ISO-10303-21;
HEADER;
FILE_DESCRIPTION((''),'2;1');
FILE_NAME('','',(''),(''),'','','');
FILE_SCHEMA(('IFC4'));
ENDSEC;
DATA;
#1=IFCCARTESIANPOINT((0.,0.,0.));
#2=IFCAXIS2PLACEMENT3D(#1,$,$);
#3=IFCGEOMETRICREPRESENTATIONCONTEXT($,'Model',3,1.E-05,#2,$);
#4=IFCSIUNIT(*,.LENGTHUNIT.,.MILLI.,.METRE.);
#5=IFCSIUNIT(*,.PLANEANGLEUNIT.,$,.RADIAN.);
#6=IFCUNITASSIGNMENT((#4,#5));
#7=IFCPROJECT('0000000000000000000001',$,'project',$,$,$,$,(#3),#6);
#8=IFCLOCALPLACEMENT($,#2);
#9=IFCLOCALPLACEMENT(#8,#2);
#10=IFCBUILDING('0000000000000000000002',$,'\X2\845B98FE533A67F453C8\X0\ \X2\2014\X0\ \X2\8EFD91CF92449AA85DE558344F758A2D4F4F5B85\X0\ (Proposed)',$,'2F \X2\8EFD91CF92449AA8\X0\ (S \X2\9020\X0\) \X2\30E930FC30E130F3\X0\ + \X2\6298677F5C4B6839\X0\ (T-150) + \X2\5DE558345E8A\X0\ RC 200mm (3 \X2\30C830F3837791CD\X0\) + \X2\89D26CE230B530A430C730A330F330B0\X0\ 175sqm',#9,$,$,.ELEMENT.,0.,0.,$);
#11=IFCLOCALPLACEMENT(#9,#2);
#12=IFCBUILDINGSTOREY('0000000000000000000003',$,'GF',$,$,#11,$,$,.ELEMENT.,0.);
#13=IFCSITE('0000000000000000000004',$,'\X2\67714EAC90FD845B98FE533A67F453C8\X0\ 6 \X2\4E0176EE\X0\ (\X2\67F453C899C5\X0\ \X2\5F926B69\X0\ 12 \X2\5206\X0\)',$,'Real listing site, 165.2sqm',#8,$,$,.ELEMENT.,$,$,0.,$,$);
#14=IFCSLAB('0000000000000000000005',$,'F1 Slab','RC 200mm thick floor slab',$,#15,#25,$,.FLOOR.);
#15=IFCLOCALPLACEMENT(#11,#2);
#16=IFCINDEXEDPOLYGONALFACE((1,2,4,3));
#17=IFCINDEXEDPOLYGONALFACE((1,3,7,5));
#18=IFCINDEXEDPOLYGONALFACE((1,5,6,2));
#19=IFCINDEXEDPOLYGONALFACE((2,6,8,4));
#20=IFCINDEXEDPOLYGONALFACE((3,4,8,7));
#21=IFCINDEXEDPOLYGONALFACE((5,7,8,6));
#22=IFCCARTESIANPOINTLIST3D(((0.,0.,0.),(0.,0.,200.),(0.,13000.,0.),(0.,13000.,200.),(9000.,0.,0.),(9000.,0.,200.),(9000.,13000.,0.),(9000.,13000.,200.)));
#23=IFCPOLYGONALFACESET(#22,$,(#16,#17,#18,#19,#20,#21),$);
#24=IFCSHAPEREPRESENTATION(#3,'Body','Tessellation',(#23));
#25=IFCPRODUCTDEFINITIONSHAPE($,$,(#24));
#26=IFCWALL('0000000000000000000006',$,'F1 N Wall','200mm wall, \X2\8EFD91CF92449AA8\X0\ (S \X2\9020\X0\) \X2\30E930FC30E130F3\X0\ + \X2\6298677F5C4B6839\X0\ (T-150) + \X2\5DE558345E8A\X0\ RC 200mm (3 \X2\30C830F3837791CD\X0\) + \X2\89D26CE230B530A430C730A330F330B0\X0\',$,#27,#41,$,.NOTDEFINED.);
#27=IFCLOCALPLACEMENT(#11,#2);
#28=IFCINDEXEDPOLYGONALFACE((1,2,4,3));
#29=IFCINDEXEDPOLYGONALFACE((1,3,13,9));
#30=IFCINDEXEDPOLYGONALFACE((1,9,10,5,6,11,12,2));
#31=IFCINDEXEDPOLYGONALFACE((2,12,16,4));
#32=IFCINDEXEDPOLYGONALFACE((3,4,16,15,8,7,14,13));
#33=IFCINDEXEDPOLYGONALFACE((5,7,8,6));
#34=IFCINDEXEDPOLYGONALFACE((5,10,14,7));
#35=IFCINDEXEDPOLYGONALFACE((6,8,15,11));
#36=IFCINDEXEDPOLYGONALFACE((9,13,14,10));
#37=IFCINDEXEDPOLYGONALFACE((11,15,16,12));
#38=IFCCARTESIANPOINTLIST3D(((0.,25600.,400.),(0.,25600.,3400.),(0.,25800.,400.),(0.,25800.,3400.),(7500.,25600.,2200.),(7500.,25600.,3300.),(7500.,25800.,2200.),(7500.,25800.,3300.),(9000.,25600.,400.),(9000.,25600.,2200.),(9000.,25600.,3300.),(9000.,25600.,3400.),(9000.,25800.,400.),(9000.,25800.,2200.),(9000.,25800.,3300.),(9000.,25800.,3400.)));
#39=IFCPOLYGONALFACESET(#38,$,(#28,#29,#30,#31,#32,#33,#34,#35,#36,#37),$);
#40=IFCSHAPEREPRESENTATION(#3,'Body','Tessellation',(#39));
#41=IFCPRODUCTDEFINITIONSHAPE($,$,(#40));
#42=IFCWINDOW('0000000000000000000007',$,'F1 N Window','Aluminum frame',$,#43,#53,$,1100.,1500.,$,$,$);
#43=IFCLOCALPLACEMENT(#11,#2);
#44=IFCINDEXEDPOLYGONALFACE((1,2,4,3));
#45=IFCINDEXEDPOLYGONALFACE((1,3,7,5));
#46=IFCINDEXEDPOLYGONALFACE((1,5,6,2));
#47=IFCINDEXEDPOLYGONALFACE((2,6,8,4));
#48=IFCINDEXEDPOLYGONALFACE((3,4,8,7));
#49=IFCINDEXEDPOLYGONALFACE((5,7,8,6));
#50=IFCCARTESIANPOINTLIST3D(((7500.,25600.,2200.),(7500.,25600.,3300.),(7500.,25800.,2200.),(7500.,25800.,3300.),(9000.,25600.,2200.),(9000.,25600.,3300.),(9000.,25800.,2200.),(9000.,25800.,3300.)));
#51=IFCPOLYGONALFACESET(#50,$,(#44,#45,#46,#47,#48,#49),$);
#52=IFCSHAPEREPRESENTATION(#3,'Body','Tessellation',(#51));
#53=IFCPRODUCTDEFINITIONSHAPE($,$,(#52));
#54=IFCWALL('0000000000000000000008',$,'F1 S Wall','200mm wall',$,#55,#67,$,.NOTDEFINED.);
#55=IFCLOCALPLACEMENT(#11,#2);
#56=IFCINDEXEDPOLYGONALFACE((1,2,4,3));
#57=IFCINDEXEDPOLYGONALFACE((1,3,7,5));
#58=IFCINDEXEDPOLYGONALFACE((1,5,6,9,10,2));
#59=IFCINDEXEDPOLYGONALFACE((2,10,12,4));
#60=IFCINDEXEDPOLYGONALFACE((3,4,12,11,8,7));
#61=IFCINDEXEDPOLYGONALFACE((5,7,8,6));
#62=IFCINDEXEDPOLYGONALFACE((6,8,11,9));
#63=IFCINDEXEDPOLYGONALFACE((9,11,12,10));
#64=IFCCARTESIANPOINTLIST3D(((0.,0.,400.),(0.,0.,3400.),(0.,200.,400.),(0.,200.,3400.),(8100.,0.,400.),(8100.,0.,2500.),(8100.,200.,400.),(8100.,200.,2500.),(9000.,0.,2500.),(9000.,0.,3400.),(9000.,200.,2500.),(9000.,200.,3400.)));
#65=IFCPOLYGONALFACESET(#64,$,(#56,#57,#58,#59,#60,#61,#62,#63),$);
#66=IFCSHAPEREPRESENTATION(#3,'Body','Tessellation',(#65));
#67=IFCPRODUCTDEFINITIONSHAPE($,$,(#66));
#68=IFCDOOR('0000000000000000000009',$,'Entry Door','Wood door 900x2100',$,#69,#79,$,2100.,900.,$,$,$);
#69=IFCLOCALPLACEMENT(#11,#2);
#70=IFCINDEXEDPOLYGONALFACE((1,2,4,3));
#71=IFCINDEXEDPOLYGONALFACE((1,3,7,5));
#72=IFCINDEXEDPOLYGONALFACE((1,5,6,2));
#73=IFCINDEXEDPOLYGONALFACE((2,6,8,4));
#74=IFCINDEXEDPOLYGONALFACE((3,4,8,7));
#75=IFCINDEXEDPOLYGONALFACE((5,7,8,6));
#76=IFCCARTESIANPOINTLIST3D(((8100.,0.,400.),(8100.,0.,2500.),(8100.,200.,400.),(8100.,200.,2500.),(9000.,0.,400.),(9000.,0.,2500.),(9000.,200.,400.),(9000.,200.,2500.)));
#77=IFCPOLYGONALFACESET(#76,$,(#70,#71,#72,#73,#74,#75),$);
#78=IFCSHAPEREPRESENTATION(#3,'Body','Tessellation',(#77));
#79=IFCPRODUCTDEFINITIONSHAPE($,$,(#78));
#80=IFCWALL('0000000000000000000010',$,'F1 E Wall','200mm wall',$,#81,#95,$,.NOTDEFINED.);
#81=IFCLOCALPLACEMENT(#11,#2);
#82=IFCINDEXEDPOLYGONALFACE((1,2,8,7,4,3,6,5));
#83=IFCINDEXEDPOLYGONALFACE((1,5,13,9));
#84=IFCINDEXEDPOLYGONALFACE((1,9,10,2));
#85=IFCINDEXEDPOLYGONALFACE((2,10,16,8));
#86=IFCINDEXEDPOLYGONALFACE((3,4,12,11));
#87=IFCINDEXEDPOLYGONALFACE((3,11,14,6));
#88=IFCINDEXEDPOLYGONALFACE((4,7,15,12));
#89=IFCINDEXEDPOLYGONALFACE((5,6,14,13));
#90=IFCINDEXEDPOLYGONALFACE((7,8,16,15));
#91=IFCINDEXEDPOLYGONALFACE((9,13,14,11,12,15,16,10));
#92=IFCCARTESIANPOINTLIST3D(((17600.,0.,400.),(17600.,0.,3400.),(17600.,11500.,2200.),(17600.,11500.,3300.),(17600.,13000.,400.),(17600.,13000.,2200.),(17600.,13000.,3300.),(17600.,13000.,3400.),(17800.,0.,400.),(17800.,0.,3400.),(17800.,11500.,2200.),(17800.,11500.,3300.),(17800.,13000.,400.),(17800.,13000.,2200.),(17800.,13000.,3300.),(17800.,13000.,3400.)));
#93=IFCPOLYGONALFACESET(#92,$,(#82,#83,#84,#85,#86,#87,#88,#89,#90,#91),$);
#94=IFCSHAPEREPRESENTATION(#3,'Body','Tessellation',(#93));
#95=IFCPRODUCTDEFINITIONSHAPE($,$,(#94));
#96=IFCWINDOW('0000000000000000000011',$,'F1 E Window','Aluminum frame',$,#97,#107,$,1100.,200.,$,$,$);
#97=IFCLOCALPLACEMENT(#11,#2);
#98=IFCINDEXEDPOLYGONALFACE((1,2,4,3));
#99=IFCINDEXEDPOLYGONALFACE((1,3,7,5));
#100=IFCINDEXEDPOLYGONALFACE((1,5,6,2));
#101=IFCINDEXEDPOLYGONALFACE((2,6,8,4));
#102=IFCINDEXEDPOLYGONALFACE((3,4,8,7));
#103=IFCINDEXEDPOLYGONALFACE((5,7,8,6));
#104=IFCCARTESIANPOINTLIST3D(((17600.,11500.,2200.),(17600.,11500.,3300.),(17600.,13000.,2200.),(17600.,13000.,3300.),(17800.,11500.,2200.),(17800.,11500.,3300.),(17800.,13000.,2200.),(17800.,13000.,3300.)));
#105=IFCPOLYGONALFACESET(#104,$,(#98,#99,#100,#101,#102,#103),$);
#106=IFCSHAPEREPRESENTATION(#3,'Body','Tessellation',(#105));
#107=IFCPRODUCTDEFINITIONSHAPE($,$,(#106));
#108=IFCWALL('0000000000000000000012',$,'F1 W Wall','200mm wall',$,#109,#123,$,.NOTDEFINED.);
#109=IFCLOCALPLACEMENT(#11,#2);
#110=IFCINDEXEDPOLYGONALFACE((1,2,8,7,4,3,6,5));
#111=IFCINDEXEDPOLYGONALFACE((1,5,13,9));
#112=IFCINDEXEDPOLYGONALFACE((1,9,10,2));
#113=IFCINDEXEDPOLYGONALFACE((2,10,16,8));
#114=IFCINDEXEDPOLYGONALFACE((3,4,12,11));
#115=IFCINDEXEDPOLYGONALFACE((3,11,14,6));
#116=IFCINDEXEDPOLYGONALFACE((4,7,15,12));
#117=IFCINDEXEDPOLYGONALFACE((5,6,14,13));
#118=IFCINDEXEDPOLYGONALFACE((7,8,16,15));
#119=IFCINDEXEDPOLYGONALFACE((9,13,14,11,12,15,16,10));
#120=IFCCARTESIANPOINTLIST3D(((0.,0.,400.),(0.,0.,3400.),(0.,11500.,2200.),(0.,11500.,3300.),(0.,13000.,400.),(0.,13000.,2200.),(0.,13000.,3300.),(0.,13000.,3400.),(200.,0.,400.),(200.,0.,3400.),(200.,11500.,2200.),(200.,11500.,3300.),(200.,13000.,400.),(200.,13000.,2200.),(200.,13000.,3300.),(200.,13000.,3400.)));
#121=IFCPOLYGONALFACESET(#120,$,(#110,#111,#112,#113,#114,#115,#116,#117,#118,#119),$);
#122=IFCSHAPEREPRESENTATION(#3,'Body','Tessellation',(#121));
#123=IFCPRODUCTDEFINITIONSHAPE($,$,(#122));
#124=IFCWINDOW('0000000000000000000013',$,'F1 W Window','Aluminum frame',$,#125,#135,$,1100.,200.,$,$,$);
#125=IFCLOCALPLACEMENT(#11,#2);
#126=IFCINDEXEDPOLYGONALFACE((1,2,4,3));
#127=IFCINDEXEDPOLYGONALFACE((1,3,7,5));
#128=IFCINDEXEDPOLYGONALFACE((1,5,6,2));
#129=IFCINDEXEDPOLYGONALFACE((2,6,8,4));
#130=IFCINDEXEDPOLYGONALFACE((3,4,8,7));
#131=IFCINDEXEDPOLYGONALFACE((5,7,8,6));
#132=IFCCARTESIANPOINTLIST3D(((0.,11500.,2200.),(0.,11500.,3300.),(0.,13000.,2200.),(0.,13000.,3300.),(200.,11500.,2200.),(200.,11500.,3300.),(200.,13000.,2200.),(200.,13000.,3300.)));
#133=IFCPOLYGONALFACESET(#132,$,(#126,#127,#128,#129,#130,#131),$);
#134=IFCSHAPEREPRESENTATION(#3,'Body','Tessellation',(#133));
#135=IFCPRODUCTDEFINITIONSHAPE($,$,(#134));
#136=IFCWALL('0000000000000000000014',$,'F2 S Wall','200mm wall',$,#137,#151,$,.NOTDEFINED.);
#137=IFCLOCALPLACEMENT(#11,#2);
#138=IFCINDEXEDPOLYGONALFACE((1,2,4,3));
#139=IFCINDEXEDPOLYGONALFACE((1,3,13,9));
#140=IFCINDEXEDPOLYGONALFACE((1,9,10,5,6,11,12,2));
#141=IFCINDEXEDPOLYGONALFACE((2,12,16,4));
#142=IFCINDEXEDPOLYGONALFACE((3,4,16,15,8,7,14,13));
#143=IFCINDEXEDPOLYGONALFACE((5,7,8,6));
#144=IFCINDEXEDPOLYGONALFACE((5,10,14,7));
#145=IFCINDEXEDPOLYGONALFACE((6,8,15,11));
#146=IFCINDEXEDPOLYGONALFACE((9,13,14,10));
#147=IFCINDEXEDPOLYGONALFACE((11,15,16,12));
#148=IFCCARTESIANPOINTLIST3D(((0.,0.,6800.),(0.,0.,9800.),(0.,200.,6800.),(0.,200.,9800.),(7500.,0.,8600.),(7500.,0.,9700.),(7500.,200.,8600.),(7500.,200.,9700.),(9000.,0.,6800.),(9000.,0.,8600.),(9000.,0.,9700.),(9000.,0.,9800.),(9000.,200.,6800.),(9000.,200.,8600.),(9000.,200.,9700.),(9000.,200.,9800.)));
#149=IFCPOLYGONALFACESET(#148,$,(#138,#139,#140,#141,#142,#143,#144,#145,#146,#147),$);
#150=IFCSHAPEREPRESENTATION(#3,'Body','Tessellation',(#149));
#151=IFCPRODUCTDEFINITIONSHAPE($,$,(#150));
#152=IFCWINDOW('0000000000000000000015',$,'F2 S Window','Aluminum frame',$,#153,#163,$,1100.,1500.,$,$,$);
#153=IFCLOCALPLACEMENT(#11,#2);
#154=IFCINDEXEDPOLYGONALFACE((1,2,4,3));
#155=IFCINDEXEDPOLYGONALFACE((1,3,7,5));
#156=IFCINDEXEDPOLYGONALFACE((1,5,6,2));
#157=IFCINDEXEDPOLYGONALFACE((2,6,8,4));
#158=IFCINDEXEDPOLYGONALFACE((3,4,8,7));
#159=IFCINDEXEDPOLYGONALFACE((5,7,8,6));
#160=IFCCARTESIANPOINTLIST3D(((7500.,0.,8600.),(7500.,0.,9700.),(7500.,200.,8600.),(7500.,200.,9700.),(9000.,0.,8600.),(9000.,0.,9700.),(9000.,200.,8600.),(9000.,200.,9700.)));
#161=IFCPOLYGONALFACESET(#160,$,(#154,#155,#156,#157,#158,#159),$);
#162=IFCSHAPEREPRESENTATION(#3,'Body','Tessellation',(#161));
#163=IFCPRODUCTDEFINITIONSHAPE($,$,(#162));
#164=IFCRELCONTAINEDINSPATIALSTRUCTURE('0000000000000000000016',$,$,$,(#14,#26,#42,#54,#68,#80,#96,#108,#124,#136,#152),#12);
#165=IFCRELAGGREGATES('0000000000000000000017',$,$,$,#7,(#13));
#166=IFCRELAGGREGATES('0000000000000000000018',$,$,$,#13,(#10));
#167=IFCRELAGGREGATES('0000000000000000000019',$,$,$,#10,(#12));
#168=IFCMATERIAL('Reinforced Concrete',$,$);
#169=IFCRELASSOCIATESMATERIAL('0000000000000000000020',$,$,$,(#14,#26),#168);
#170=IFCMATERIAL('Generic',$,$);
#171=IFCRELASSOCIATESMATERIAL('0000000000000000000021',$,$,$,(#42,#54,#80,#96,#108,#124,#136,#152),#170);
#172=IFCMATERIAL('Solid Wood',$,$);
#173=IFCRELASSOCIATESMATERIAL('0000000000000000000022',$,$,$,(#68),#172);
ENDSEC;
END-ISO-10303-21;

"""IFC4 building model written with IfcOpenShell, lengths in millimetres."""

from ifc_helpers import new_model, si_unit, frame, frame_2d, origin, place, context, project, spatial, rectangle, extrude, material, element, fill, save


model = new_model("IFC4")

# Units and contexts
model_context = context("Model", 3, precision=1e-05, world=origin())
ifc_project = project(units=[si_unit("LENGTHUNIT", "METRE", prefix="MILLI"), si_unit("PLANEANGLEUNIT", "RADIAN")], contexts=[model_context])

# Site, building, storey
site_placement = place(None, origin())
site = spatial("IfcSite", under=ifc_project, at=site_placement, Name="東京都葛飾区柴又 6 丁目 (柴又駅 徒歩 12 分)", ObjectType="Real listing site, 165.2sqm", CompositionType="ELEMENT", RefElevation=0.0)
building_placement = place(site_placement, origin())
building = spatial("IfcBuilding", under=site, at=building_placement, Name="葛飾区柴又 — 軽量鉄骨工場併設住宅 (Proposed)", ObjectType="2F 軽量鉄骨 (S 造) ラーメン + 折板屋根 (T-150) + 工場床 RC 200mm (3 トン荷重) + 角波サイディング 175sqm", CompositionType="ELEMENT", ElevationOfRefHeight=0.0, ElevationOfTerrain=0.0)
storey_placement = place(building_placement, origin())
storey = spatial("IfcBuildingStorey", under=building, at=storey_placement, Name="GF", CompositionType="ELEMENT", Elevation=0.0)

# Slab
ifc_material_1 = material(Name="Reinforced Concrete")
slab_1_placement = place(storey_placement, origin())
element("IfcSlab", 1, at=slab_1_placement, inside=storey, material=ifc_material_1, Name="F1 Slab", Description="RC 200mm thick floor slab", PredefinedType="FLOOR", context=model_context, shape_type="SweptSolid", body=[
    extrude(rectangle(XDim=9000.0, YDim=13000.0, at=frame_2d((4500.0, 6500.0))), origin(), (0.0, 0.0, 1.0), 200.0),
])

# Wall, opening, window
wall_1_placement = place(storey_placement, frame((0.0, 12800.0, 200.0)))
wall_1 = element("IfcWall", 2, at=wall_1_placement, inside=storey, material=ifc_material_1, Name="F1 N Wall", Description="200mm wall, 軽量鉄骨 (S 造) ラーメン + 折板屋根 (T-150) + 工場床 RC 200mm (3 トン荷重) + 角波サイディング", PredefinedType="NOTDEFINED", context=model_context, shape_type="SweptSolid", body=[
    extrude(rectangle(XDim=9000.0, YDim=200.0, at=frame_2d((4500.0, 100.0))), frame((0.0, 12800.0, 200.0)), (0.0, 0.0, 1.0), 3000.0),
])
opening_1_placement = place(storey_placement, frame((3750.0, 12800.0, 1100.0)))
opening_1 = element("IfcOpeningElement", 3, at=opening_1_placement, cuts=wall_1, PredefinedType="NOTDEFINED", context=model_context, shape_type="SweptSolid", body=[
    extrude(rectangle(XDim=1500.0, YDim=200.0, at=frame_2d((750.0, 100.0))), frame((3750.0, 12800.0, 1100.0)), (0.0, 0.0, 1.0), 1100.0),
])
ifc_material_2 = material(Name="Generic")
window_1_placement = place(storey_placement, frame((3750.0, 12800.0, 1100.0)))
window_1 = element("IfcWindow", 4, at=window_1_placement, inside=storey, material=ifc_material_2, Name="F1 N Window", Description="Aluminum frame", OverallHeight=1100.0, OverallWidth=1500.0, context=model_context, shape_type="SweptSolid", body=[
    extrude(rectangle(XDim=1500.0, YDim=200.0, at=frame_2d((750.0, 100.0))), frame((3750.0, 12800.0, 1100.0)), (0.0, 0.0, 1.0), 1100.0),
])
fill(opening_1, window_1)

# Wall, opening, door
wall_2_placement = place(storey_placement, frame((0.0, 0.0, 200.0)))
wall_2 = element("IfcWall", 5, at=wall_2_placement, inside=storey, material=ifc_material_2, Name="F1 S Wall", Description="200mm wall", PredefinedType="NOTDEFINED", context=model_context, shape_type="SweptSolid", body=[
    extrude(rectangle(XDim=9000.0, YDim=200.0, at=frame_2d((4500.0, 100.0))), frame((0.0, 0.0, 200.0)), (0.0, 0.0, 1.0), 3000.0),
])
opening_2_placement = place(storey_placement, frame((4050.0, 0.0, 200.0)))
opening_2 = element("IfcOpeningElement", 6, at=opening_2_placement, cuts=wall_2, PredefinedType="NOTDEFINED", context=model_context, shape_type="SweptSolid", body=[
    extrude(rectangle(XDim=900.0, YDim=200.0, at=frame_2d((450.0, 100.0))), frame((4050.0, 0.0, 200.0)), (0.0, 0.0, 1.0), 2100.0),
])
ifc_material_3 = material(Name="Solid Wood")
door_placement = place(storey_placement, frame((4050.0, 0.0, 200.0)))
door = element("IfcDoor", 7, at=door_placement, inside=storey, material=ifc_material_3, Name="Entry Door", Description="Wood door 900x2100", OverallHeight=2100.0, OverallWidth=900.0, context=model_context, shape_type="SweptSolid", body=[
    extrude(rectangle(XDim=900.0, YDim=200.0, at=frame_2d((450.0, 100.0))), frame((4050.0, 0.0, 200.0)), (0.0, 0.0, 1.0), 2100.0),
])
fill(opening_2, door)

# Walls, openings, windows
wall_3_placement = place(storey_placement, frame((8800.0, 0.0, 200.0)))
wall_3 = element("IfcWall", 8, at=wall_3_placement, inside=storey, material=ifc_material_2, Name="F1 E Wall", Description="200mm wall", PredefinedType="NOTDEFINED", context=model_context, shape_type="SweptSolid", body=[
    extrude(rectangle(XDim=200.0, YDim=13000.0, at=frame_2d((100.0, 6500.0))), frame((8800.0, 0.0, 200.0)), (0.0, 0.0, 1.0), 3000.0),
])
opening_3_placement = place(storey_placement, frame((8800.0, 5750.0, 1100.0)))
opening_3 = element("IfcOpeningElement", 9, at=opening_3_placement, cuts=wall_3, PredefinedType="NOTDEFINED", context=model_context, shape_type="SweptSolid", body=[
    extrude(rectangle(XDim=200.0, YDim=1500.0, at=frame_2d((100.0, 750.0))), frame((8800.0, 5750.0, 1100.0)), (0.0, 0.0, 1.0), 1100.0),
])
window_2_placement = place(storey_placement, frame((8800.0, 5750.0, 1100.0)))
window_2 = element("IfcWindow", 10, at=window_2_placement, inside=storey, material=ifc_material_2, Name="F1 E Window", Description="Aluminum frame", OverallHeight=1100.0, OverallWidth=200.0, context=model_context, shape_type="SweptSolid", body=[
    extrude(rectangle(XDim=200.0, YDim=1500.0, at=frame_2d((100.0, 750.0))), frame((8800.0, 5750.0, 1100.0)), (0.0, 0.0, 1.0), 1100.0),
])
fill(opening_3, window_2)
wall_4_placement = place(storey_placement, frame((0.0, 0.0, 200.0)))
wall_4 = element("IfcWall", 11, at=wall_4_placement, inside=storey, material=ifc_material_2, Name="F1 W Wall", Description="200mm wall", PredefinedType="NOTDEFINED", context=model_context, shape_type="SweptSolid", body=[
    extrude(rectangle(XDim=200.0, YDim=13000.0, at=frame_2d((100.0, 6500.0))), frame((0.0, 0.0, 200.0)), (0.0, 0.0, 1.0), 3000.0),
])
opening_4_placement = place(storey_placement, frame((0.0, 5750.0, 1100.0)))
opening_4 = element("IfcOpeningElement", 12, at=opening_4_placement, cuts=wall_4, PredefinedType="NOTDEFINED", context=model_context, shape_type="SweptSolid", body=[
    extrude(rectangle(XDim=200.0, YDim=1500.0, at=frame_2d((100.0, 750.0))), frame((0.0, 5750.0, 1100.0)), (0.0, 0.0, 1.0), 1100.0),
])
window_3_placement = place(storey_placement, frame((0.0, 5750.0, 1100.0)))
window_3 = element("IfcWindow", 13, at=window_3_placement, inside=storey, material=ifc_material_2, Name="F1 W Window", Description="Aluminum frame", OverallHeight=1100.0, OverallWidth=200.0, context=model_context, shape_type="SweptSolid", body=[
    extrude(rectangle(XDim=200.0, YDim=1500.0, at=frame_2d((100.0, 750.0))), frame((0.0, 5750.0, 1100.0)), (0.0, 0.0, 1.0), 1100.0),
])
fill(opening_4, window_3)
wall_5_placement = place(storey_placement, frame((0.0, 0.0, 3400.0)))
wall_5 = element("IfcWall", 14, at=wall_5_placement, inside=storey, material=ifc_material_2, Name="F2 S Wall", Description="200mm wall", PredefinedType="NOTDEFINED", context=model_context, shape_type="SweptSolid", body=[
    extrude(rectangle(XDim=9000.0, YDim=200.0, at=frame_2d((4500.0, 100.0))), frame((0.0, 0.0, 3400.0)), (0.0, 0.0, 1.0), 3000.0),
])
opening_5_placement = place(storey_placement, frame((3750.0, 0.0, 4300.0)))
opening_5 = element("IfcOpeningElement", 15, at=opening_5_placement, cuts=wall_5, PredefinedType="NOTDEFINED", context=model_context, shape_type="SweptSolid", body=[
    extrude(rectangle(XDim=1500.0, YDim=200.0, at=frame_2d((750.0, 100.0))), frame((3750.0, 0.0, 4300.0)), (0.0, 0.0, 1.0), 1100.0),
])
window_4_placement = place(storey_placement, frame((3750.0, 0.0, 4300.0)))
window_4 = element("IfcWindow", 16, at=window_4_placement, inside=storey, material=ifc_material_2, Name="F2 S Window", Description="Aluminum frame", OverallHeight=1100.0, OverallWidth=1500.0, context=model_context, shape_type="SweptSolid", body=[
    extrude(rectangle(XDim=1500.0, YDim=200.0, at=frame_2d((750.0, 100.0))), frame((3750.0, 0.0, 4300.0)), (0.0, 0.0, 1.0), 1100.0),
])
fill(opening_5, window_4)

save(model, "model.ifc")
